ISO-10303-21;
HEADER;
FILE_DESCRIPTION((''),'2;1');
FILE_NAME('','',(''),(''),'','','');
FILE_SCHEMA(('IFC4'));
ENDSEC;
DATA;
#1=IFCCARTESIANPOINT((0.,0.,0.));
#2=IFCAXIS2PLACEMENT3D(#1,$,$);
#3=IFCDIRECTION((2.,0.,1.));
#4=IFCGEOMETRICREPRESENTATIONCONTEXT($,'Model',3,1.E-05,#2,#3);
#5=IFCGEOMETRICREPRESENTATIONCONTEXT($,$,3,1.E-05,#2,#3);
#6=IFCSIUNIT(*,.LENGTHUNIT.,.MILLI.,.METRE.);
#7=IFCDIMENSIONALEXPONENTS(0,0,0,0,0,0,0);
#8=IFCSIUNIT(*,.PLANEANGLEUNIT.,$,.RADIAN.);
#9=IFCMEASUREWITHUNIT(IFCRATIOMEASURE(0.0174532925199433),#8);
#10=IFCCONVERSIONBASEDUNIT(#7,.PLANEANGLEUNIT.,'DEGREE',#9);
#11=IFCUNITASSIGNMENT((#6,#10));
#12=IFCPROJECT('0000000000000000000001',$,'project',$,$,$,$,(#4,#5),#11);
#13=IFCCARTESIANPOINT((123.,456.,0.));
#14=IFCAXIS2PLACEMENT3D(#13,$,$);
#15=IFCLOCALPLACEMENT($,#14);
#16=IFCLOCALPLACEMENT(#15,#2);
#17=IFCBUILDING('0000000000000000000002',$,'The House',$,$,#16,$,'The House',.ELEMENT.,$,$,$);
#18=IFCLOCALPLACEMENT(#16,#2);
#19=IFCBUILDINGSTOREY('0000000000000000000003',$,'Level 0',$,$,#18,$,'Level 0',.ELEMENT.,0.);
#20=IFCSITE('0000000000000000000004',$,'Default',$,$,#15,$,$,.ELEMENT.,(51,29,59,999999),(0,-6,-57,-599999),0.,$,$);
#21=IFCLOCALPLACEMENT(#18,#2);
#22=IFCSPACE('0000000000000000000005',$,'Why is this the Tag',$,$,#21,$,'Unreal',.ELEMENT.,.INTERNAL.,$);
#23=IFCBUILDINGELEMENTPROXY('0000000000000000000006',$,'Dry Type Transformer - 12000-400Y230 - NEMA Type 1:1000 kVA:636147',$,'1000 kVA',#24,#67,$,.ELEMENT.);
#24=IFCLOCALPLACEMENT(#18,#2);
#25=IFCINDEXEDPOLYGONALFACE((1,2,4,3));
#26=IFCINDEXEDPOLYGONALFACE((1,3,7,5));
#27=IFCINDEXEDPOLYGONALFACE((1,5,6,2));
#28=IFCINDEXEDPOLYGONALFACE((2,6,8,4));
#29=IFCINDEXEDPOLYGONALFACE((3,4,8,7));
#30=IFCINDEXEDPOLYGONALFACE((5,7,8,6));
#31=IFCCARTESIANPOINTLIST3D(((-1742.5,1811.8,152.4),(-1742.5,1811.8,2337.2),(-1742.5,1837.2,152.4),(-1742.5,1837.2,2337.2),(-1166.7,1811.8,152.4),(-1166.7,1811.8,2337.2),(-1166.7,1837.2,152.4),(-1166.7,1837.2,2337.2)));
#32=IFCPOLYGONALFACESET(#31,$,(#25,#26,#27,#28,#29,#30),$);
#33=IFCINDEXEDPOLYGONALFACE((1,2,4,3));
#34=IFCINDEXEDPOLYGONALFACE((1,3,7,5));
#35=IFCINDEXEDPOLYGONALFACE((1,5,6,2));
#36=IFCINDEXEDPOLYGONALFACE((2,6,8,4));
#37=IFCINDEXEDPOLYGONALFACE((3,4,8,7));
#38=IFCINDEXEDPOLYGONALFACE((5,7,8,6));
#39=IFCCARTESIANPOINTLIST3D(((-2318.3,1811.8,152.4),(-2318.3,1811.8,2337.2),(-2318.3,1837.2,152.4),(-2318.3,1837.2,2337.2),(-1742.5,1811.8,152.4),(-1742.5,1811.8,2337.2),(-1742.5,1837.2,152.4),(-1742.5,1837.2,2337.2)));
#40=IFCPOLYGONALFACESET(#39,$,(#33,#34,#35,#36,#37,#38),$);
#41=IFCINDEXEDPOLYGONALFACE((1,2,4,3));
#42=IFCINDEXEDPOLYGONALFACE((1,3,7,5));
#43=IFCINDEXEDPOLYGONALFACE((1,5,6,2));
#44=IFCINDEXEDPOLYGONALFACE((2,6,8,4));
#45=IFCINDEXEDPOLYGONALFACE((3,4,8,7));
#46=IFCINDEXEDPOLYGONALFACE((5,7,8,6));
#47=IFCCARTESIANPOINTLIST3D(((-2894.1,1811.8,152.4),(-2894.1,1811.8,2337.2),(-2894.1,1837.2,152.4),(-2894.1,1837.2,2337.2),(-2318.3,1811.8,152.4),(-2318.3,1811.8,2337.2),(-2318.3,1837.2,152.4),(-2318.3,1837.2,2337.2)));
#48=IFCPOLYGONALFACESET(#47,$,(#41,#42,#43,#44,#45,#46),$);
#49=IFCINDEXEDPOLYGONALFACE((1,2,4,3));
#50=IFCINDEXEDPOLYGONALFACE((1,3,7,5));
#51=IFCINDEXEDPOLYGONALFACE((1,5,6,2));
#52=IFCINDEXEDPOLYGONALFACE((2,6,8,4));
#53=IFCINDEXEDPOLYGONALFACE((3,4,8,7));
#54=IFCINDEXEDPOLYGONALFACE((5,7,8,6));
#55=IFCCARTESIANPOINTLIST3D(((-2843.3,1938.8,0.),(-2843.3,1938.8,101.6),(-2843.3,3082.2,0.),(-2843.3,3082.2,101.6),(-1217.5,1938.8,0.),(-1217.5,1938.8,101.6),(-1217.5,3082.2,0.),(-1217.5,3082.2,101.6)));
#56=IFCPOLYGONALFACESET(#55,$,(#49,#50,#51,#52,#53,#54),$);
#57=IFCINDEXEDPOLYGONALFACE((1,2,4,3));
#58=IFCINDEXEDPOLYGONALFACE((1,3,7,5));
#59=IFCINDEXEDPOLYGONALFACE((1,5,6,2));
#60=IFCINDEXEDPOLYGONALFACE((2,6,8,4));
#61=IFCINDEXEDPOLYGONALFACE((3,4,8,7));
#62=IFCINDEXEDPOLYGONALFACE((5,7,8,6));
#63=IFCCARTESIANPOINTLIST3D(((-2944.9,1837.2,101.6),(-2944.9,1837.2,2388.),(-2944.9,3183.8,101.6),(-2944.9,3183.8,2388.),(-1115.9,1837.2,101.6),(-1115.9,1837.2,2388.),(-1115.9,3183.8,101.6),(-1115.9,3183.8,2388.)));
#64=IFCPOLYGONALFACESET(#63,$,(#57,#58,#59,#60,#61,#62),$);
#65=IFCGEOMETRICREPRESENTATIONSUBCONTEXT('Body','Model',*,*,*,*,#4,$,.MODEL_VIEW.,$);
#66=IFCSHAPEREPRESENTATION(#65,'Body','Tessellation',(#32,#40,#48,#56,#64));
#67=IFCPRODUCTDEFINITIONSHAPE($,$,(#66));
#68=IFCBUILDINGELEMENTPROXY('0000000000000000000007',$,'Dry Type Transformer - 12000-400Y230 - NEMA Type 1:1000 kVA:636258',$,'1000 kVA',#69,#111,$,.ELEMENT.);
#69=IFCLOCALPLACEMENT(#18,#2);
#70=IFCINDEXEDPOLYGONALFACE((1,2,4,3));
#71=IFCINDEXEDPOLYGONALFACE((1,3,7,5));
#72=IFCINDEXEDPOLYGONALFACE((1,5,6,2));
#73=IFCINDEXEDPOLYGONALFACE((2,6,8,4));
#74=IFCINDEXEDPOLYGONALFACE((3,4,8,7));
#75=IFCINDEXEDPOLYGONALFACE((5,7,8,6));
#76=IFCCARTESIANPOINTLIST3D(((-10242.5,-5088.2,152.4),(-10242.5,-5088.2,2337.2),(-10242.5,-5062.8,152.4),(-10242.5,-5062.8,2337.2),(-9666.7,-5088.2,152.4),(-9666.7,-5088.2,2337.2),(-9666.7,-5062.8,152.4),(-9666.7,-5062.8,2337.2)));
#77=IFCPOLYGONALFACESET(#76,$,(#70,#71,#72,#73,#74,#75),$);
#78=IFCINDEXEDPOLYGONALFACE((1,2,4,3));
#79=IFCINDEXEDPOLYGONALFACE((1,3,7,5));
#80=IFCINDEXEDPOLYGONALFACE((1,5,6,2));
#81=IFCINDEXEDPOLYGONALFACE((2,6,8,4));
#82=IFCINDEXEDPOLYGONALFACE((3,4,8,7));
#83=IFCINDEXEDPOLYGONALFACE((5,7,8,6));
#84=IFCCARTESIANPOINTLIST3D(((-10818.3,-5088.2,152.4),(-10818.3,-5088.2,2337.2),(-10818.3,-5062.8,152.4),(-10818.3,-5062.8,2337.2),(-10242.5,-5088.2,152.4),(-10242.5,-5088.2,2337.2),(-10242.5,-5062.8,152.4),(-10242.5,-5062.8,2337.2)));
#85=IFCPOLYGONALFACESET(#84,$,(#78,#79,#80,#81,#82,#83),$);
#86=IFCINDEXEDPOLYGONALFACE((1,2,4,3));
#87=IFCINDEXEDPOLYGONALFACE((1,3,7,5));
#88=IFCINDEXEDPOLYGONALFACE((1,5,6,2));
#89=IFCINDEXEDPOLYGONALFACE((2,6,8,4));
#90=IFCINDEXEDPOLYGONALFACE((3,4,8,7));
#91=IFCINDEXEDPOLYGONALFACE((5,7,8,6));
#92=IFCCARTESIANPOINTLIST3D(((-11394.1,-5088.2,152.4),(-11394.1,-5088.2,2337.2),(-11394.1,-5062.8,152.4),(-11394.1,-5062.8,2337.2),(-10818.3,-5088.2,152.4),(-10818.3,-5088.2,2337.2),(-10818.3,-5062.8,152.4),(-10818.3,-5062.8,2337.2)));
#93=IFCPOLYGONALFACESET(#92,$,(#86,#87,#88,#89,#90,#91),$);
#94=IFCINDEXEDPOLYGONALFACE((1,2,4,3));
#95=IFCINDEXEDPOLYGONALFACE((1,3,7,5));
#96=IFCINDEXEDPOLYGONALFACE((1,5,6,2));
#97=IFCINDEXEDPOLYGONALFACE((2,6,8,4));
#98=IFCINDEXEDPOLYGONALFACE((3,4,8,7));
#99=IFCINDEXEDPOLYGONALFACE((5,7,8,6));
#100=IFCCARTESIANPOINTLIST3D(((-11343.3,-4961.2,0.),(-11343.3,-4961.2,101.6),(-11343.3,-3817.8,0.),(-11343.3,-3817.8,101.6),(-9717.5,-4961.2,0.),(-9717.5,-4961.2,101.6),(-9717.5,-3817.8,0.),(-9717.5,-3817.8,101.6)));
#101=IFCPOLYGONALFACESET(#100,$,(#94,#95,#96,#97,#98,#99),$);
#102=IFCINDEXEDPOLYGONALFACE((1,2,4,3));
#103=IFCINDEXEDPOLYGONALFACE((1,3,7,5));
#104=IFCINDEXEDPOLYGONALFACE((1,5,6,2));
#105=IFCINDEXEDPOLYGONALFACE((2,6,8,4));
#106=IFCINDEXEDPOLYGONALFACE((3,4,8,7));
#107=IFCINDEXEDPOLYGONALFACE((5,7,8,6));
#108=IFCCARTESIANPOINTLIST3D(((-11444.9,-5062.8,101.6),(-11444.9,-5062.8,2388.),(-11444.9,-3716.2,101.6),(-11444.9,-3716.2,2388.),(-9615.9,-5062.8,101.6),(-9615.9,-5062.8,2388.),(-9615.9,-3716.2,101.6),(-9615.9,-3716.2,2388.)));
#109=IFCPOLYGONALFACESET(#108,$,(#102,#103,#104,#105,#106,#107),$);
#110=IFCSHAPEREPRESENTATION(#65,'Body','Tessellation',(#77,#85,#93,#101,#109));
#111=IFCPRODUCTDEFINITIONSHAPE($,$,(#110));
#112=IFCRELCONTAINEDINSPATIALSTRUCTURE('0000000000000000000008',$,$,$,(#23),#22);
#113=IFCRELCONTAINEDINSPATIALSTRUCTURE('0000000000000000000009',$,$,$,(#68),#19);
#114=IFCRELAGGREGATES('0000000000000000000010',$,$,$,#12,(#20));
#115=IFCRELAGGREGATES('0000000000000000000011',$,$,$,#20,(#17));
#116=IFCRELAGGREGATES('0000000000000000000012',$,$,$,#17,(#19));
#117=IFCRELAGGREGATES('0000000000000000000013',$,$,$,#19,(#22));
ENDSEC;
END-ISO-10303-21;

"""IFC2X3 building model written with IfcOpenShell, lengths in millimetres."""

from ifc_helpers import new_model, entity, si_unit, converted_unit, direction, frame, frame_2d, origin, origin_2d_with_axis, place, context, subcontext, project, spatial, rectangle, extrude, source, transform, mapped, element, save


model = new_model("IFC2X3")

# Units and contexts
model_context = context("Model", 3, precision=1e-05, world=origin(), true_north=direction((2.0, 0.0, 1.0)))
context_of_model = context(None, 3, precision=1e-05, world=origin(), true_north=direction((2.0, 0.0, 1.0)))
body_context = subcontext(model_context, "Body", "Model", "MODEL_VIEW")
ifc_project = project(units=[si_unit("LENGTHUNIT", "METRE", prefix="MILLI"), converted_unit("PLANEANGLEUNIT", "DEGREE", entity("IfcRatioMeasure", 0.0174532925199433), si_unit("PLANEANGLEUNIT", "RADIAN"), dimensions=[0, 0, 0, 0, 0, 0, 0])], contexts=[model_context, context_of_model])

# Site, building, storey
site_placement = place(None, frame((123.0, 456.0, 0.0)))
site = spatial("IfcSite", under=ifc_project, at=site_placement, Name="Default", CompositionType="ELEMENT", RefLatitude=(51, 29, 59, 999999), RefLongitude=(0, -6, -57, -599999), RefElevation=0.0)
building_placement = place(site_placement, origin())
building = spatial("IfcBuilding", under=site, at=building_placement, Name="The House", LongName="The House", CompositionType="ELEMENT")
storey_placement = place(building_placement, origin())
storey = spatial("IfcBuildingStorey", under=building, at=storey_placement, Name="Level 0", LongName="Level 0", CompositionType="ELEMENT", Elevation=0.0)

# Shared definitions
shared_shape = source(origin(), body_context, "Body", "SweptSolid", [
    extrude(rectangle(XDim=575.8, YDim=25.4, at=frame_2d((0.0, 0.0), x_axis=(1.0, 0.0))), frame((575.8, -1359.3, 152.4), z_axis=(0.0, 0.0, 1.0), x_axis=(-1.0, 0.0, 0.0)), (0.0, 0.0, 1.0), 2184.8),
    extrude(rectangle(XDim=575.8, YDim=25.4, at=origin_2d_with_axis()), frame((0.0, -1359.3, 152.4), z_axis=(0.0, 0.0, 1.0), x_axis=(-1.0, 0.0, 0.0)), (0.0, 0.0, 1.0), 2184.8),
    extrude(rectangle(XDim=575.8, YDim=25.4, at=origin_2d_with_axis()), frame((-575.8, -1359.3, 152.4), z_axis=(0.0, 0.0, 1.0), x_axis=(-1.0, 0.0, 0.0)), (0.0, 0.0, 1.0), 2184.8),
    extrude(rectangle(XDim=1625.8, YDim=1143.4, at=frame_2d((0.0, 0.0), x_axis=(1.0, 0.0))), frame((0.0, -673.3, 0.0), z_axis=(0.0, 0.0, 1.0), x_axis=(-1.0, 0.0, 0.0)), (0.0, 0.0, 1.0), 101.6),
    extrude(rectangle(XDim=1829.0, YDim=1346.6, at=origin_2d_with_axis()), frame((0.0, -673.3, 101.6), z_axis=(0.0, 0.0, 1.0), x_axis=(-1.0, 0.0, 0.0)), (0.0, 0.0, 1.0), 2286.4),
])

# Shared definitions
space_1_placement = place(storey_placement, origin())
space_1 = spatial("IfcSpace", under=storey, at=space_1_placement, Name="Why is this the Tag", LongName="Unreal", CompositionType="ELEMENT", InteriorOrExteriorSpace="INTERNAL")

# Building element proxies
proxy_1_placement = place(space_1_placement, frame((-2030.4, 3183.8, 0.0)))
element("IfcBuildingElementProxy", 1, at=proxy_1_placement, inside=space_1, Name="Dry Type Transformer - 12000-400Y230 - NEMA Type 1:1000 kVA:636147", ObjectType="1000 kVA", CompositionType="ELEMENT", context=body_context, shape_type="MappedRepresentation", body=[
    mapped(shared_shape, transform((0.0, 0.0, 0.0), scale=1.0)),
])
proxy_2_placement = place(storey_placement, frame((-10530.4, -3716.2, 0.0)))
element("IfcBuildingElementProxy", 2, at=proxy_2_placement, inside=storey, Name="Dry Type Transformer - 12000-400Y230 - NEMA Type 1:1000 kVA:636258", ObjectType="1000 kVA", CompositionType="ELEMENT", context=body_context, shape_type="MappedRepresentation", body=[
    mapped(shared_shape, transform((0.0, 0.0, 0.0), scale=1.0)),
])

save(model, "model.ifc")
